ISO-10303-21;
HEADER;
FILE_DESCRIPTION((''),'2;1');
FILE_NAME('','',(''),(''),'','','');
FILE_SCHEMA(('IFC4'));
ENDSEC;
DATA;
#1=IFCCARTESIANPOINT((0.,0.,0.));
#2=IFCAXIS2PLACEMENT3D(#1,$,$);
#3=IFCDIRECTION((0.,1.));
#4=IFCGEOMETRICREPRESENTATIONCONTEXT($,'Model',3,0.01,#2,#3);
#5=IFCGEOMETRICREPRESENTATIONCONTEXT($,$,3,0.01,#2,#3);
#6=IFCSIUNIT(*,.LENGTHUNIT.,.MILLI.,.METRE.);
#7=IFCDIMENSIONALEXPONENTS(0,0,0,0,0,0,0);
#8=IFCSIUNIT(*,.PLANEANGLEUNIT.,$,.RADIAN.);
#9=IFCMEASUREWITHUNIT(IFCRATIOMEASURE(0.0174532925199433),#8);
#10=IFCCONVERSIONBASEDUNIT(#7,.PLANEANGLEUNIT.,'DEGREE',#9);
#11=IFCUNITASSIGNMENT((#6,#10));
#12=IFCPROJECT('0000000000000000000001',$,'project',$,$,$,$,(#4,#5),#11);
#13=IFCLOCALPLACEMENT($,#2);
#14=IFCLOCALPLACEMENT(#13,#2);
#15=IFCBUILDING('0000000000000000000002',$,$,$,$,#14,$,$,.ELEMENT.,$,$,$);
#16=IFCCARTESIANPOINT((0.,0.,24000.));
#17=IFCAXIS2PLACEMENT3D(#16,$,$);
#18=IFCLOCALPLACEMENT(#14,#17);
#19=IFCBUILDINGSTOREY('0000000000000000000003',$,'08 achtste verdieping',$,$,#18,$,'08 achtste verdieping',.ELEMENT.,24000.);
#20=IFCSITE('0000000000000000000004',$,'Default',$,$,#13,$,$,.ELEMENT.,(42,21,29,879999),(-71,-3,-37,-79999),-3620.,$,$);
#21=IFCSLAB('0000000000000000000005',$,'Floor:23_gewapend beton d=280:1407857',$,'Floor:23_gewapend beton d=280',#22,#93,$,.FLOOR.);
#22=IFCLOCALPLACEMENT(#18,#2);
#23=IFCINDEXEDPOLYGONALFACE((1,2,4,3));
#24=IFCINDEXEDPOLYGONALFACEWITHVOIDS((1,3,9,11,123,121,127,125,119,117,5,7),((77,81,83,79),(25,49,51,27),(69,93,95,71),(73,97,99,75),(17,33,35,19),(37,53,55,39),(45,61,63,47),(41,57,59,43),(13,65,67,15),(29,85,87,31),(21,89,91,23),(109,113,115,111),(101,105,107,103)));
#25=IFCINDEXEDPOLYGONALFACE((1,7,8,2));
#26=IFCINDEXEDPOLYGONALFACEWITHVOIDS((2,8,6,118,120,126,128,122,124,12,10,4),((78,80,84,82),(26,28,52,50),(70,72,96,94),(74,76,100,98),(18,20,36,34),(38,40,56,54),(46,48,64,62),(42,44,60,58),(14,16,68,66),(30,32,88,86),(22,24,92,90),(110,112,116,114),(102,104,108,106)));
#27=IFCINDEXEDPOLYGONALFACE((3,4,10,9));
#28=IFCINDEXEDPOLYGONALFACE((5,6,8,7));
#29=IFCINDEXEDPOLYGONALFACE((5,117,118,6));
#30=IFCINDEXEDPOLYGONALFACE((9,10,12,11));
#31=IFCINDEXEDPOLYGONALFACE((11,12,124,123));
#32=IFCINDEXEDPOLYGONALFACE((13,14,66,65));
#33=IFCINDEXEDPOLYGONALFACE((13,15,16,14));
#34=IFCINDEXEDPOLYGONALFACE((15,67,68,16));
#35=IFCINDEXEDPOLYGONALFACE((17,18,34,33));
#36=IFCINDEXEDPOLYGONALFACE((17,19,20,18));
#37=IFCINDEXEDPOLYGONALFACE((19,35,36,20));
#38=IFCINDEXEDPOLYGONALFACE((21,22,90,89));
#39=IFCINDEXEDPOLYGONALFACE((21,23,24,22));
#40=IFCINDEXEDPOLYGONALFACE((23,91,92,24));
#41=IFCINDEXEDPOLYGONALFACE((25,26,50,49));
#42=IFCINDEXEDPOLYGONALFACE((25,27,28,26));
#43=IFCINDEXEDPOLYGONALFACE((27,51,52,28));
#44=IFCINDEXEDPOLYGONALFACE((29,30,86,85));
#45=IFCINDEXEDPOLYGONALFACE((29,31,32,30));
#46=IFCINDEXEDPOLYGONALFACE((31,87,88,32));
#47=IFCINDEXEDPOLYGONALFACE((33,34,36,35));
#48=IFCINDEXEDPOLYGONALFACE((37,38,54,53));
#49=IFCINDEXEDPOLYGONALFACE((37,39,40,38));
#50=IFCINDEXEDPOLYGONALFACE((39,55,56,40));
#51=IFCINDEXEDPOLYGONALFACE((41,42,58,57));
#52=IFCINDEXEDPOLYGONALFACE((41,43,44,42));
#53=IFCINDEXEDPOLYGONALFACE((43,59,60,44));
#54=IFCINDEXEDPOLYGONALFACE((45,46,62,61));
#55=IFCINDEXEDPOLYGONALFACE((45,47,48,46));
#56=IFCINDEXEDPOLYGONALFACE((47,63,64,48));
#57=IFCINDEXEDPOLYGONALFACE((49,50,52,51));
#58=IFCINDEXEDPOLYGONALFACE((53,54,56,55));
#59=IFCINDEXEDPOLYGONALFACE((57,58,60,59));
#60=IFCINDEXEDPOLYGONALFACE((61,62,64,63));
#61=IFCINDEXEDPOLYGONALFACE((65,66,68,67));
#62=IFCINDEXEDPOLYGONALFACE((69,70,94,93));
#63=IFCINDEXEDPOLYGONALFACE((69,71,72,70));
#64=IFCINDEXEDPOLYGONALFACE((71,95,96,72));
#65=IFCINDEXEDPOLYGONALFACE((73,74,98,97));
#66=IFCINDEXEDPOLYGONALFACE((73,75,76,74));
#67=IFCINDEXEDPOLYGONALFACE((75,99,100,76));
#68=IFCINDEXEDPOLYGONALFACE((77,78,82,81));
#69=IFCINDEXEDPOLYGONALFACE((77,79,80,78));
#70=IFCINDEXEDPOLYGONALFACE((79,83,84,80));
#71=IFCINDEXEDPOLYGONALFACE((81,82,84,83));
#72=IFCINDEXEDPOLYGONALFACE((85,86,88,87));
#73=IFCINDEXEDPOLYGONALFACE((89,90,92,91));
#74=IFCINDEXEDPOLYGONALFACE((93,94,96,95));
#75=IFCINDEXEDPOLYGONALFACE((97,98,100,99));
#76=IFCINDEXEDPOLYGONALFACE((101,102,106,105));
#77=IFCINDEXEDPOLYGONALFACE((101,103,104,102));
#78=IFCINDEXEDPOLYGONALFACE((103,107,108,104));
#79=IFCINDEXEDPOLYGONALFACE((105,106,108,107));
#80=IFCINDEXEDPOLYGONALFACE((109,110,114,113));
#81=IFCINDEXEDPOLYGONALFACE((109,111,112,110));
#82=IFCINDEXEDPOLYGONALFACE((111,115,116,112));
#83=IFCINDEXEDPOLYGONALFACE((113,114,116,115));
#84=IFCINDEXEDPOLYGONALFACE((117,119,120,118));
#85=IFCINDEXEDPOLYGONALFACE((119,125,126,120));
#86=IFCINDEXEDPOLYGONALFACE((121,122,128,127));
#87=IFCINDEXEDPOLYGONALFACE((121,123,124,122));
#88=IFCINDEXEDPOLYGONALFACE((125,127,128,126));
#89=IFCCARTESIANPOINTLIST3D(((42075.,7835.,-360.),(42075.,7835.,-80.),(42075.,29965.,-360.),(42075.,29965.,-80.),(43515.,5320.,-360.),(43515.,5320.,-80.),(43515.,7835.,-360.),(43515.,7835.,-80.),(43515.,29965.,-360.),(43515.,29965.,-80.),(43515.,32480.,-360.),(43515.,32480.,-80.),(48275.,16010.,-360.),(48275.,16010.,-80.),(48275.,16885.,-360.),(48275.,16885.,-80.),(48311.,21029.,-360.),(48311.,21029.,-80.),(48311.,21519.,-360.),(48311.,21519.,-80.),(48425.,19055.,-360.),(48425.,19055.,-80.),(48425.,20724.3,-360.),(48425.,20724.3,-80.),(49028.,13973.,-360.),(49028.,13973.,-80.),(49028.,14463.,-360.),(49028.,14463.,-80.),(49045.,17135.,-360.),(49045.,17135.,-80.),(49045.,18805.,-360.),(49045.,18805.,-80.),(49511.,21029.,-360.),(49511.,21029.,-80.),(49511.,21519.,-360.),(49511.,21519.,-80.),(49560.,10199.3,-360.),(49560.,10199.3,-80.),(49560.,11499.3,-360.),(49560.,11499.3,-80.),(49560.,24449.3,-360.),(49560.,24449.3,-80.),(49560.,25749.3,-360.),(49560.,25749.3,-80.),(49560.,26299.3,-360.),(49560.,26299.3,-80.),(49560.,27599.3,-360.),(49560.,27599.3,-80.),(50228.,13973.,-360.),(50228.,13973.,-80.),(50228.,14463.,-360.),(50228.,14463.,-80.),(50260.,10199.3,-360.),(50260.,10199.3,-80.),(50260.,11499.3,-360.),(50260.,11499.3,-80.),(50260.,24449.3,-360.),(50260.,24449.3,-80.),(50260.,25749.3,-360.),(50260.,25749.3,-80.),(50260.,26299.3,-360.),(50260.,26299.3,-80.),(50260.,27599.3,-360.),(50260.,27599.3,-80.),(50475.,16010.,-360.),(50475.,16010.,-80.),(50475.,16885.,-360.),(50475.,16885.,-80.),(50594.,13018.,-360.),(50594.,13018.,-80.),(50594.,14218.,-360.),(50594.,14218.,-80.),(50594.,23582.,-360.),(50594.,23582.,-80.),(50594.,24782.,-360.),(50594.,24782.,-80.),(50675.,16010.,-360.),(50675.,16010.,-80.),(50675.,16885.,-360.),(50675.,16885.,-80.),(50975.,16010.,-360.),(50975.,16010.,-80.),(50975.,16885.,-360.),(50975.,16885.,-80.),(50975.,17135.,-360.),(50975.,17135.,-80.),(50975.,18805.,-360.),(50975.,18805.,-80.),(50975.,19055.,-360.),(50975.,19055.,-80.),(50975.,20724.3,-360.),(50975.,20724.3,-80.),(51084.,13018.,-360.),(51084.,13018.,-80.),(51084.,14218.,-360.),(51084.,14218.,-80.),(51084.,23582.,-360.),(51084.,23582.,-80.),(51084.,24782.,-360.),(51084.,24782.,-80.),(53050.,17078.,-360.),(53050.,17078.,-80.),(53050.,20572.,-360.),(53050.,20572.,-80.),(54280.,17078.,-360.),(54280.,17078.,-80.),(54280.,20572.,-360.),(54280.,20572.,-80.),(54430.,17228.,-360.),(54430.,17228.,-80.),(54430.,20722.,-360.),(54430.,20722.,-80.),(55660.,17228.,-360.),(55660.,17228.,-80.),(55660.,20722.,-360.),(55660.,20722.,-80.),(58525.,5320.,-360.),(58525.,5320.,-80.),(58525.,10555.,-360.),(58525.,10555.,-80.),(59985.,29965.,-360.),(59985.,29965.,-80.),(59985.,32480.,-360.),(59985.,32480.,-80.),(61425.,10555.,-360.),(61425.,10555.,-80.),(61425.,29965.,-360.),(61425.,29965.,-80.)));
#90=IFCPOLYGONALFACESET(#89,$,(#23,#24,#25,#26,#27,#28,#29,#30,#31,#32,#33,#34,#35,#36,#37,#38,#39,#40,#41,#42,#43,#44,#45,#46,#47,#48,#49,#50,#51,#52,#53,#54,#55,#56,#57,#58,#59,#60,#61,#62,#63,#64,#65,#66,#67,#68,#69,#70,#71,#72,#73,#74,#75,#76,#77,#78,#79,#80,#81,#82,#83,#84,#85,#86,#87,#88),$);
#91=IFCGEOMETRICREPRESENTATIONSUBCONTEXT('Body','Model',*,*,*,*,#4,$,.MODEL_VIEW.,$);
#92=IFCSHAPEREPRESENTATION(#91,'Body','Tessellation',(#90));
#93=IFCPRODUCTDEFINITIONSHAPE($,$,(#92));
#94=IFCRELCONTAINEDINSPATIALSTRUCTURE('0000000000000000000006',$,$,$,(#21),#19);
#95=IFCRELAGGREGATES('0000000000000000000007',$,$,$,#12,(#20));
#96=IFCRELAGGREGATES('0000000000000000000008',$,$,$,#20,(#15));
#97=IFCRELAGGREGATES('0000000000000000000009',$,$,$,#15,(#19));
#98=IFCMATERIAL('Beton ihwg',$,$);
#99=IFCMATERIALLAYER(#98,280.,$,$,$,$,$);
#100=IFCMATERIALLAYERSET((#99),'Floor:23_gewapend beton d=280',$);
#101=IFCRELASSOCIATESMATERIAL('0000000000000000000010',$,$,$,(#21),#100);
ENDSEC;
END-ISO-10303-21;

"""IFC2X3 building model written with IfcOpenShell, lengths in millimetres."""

from ifc_helpers import new_model, entity, si_unit, converted_unit, direction, frame, frame_2d, origin, place, context, subcontext, project, spatial, polyline, rectangle, outline, extrude, material, layer, layer_set, layer_usage, element, save


model = new_model("IFC2X3")

# Units and contexts
model_context = context("Model", 3, precision=0.01, world=origin(), true_north=direction((0.0, 1.0)))
context_of_model = context(None, 3, precision=0.01, world=origin(), true_north=direction((0.0, 1.0)))
body_context = subcontext(model_context, "Body", "Model", "MODEL_VIEW")
ifc_project = project(units=[si_unit("LENGTHUNIT", "METRE", prefix="MILLI"), converted_unit("PLANEANGLEUNIT", "DEGREE", entity("IfcRatioMeasure", 0.0174532925199433), si_unit("PLANEANGLEUNIT", "RADIAN"), dimensions=[0, 0, 0, 0, 0, 0, 0])], contexts=[model_context, context_of_model])

# Site, building, storey
site_placement = place(None, origin())
site = spatial("IfcSite", under=ifc_project, at=site_placement, Name="Default", CompositionType="ELEMENT", RefLatitude=(42, 21, 29, 879999), RefLongitude=(-71, -3, -37, -79999), RefElevation=-3620.0)
building_placement = place(site_placement, origin())
building = spatial("IfcBuilding", under=site, at=building_placement, CompositionType="ELEMENT")
storey_placement = place(building_placement, frame((0.0, 0.0, 24000.0)))
storey = spatial("IfcBuildingStorey", under=building, at=storey_placement, Name="08 achtste verdieping", LongName="08 achtste verdieping", CompositionType="ELEMENT", Elevation=24000.0)

# Slab, openings
ifc_material_1 = material(Name="Beton ihwg")
ifc_layer_1 = layer(ifc_material_1, 280.0)
ifc_layer_set_1 = layer_set([ifc_layer_1], Name="Floor:23_gewapend beton d=280")
ifc_layer_usage_1 = layer_usage(ifc_layer_set_1, "AXIS3", "POSITIVE", 0.0)
slab_1_placement = place(storey_placement, frame((42075.0, 5320.0, -360.0)))
slab_1 = element("IfcSlab", 1, at=slab_1_placement, inside=storey, material=ifc_layer_usage_1, Name="Floor:23_gewapend beton d=280:1407857", ObjectType="Floor:23_gewapend beton d=280", PredefinedType="FLOOR", context=body_context, shape_type="SweptSolid", body=[
    extrude(outline(polyline([(8235.0, 13580.0), (-8235.0, 13580.0), (-8235.0, 11065.0), (-9675.0, 11065.0), (-9675.0, -8345.0), (-6775.0, -8345.0), (-6775.0, -13580.0), (8235.0, -13580.0), (8235.0, -11065.0), (9675.0, -11065.0), (9675.0, 11065.0), (8235.0, 11065.0), (8235.0, 13580.0)])), frame((9675.0, 13580.0, 280.0), z_axis=(0.0, 0.0, -1.0), x_axis=(-1.0, 0.0, 0.0)), (0.0, 0.0, 1.0), 280.0),
])
opening_1_placement = place(storey_placement, frame((42075.0, 5320.0, -360.0)))
element("IfcOpeningElement", 2, at=opening_1_placement, cuts=slab_1, ObjectType="Opening", context=body_context, shape_type="SweptSolid", body=[
    extrude(rectangle(XDim=1669.3, YDim=2550.0, at=frame_2d((2050.0, 989.6), x_axis=(0.0, 1.0))), frame((9675.0, 13580.0, 280.0), z_axis=(0.0, 0.0, -1.0), x_axis=(-1.0, 0.0, 0.0)), (0.0, 0.0, 1.0), 280.0),
])
opening_2_placement = place(storey_placement, frame((42075.0, 5320.0, -360.0)))
element("IfcOpeningElement", 3, at=opening_2_placement, cuts=slab_1, ObjectType="Opening", context=body_context, shape_type="SweptSolid", body=[
    extrude(rectangle(XDim=1670.0, YDim=1930.0, at=frame_2d((1740.0, -930.0), x_axis=(0.0, 1.0))), frame((9675.0, 13580.0, 280.0), z_axis=(0.0, 0.0, -1.0), x_axis=(-1.0, 0.0, 0.0)), (0.0, 0.0, 1.0), 280.0),
])
opening_3_placement = place(storey_placement, frame((42075.0, 5320.0, -360.0)))
element("IfcOpeningElement", 4, at=opening_3_placement, cuts=slab_1, ObjectType="Opening", context=body_context, shape_type="SweptSolid", body=[
    extrude(rectangle(XDim=1300.0, YDim=700.0, at=frame_2d((1840.0, 8049.3), x_axis=(0.0, 1.0))), frame((9675.0, 13580.0, 280.0), z_axis=(0.0, 0.0, -1.0), x_axis=(-1.0, 0.0, 0.0)), (0.0, 0.0, 1.0), 280.0),
])
opening_4_placement = place(storey_placement, frame((42075.0, 5320.0, -360.0)))
element("IfcOpeningElement", 5, at=opening_4_placement, cuts=slab_1, ObjectType="Opening", context=body_context, shape_type="SweptSolid", body=[
    extrude(rectangle(XDim=1300.0, YDim=700.0, at=frame_2d((1840.0, 6199.3), x_axis=(0.0, 1.0))), frame((9675.0, 13580.0, 280.0), z_axis=(0.0, 0.0, -1.0), x_axis=(-1.0, 0.0, 0.0)), (0.0, 0.0, 1.0), 280.0),
])
opening_5_placement = place(storey_placement, frame((42075.0, 5320.0, -360.0)))
element("IfcOpeningElement", 6, at=opening_5_placement, cuts=slab_1, ObjectType="Opening", context=body_context, shape_type="SweptSolid", body=[
    extrude(rectangle(XDim=1300.0, YDim=700.0, at=frame_2d((1840.0, -8050.7), x_axis=(0.0, 1.0))), frame((9675.0, 13580.0, 280.0), z_axis=(0.0, 0.0, -1.0), x_axis=(-1.0, 0.0, 0.0)), (0.0, 0.0, 1.0), 280.0),
])
opening_6_placement = place(storey_placement, frame((42075.0, 5320.0, -360.0)))
element("IfcOpeningElement", 7, at=opening_6_placement, cuts=slab_1, ObjectType="Opening", context=body_context, shape_type="SweptSolid", body=[
    extrude(rectangle(XDim=875.0, YDim=2200.0, at=frame_2d((2375.0, -2452.5), x_axis=(0.0, 1.0))), frame((9675.0, 13580.0, 280.0), z_axis=(0.0, 0.0, -1.0), x_axis=(-1.0, 0.0, 0.0)), (0.0, 0.0, 1.0), 280.0),
])
opening_7_placement = place(storey_placement, frame((42075.0, 5320.0, -360.0)))
element("IfcOpeningElement", 8, at=opening_7_placement, cuts=slab_1, ObjectType="Opening", context=body_context, shape_type="SweptSolid", body=[
    extrude(rectangle(XDim=875.0, YDim=300.0, at=frame_2d((925.0, -2452.5), x_axis=(0.0, 1.0))), frame((9675.0, 13580.0, 280.0), z_axis=(0.0, 0.0, -1.0), x_axis=(-1.0, 0.0, 0.0)), (0.0, 0.0, 1.0), 280.0),
])
opening_8_placement = place(storey_placement, frame((42075.0, 5320.0, -360.0)))
element("IfcOpeningElement", 9, at=opening_8_placement, cuts=slab_1, ObjectType="Opening", context=body_context, shape_type="SweptSolid", body=[
    extrude(rectangle(XDim=3494.0, YDim=1230.0, at=frame_2d((-3295.0, 75.0), x_axis=(0.0, 1.0))), frame((9675.0, 13580.0, 280.0), z_axis=(0.0, 0.0, -1.0), x_axis=(-1.0, 0.0, 0.0)), (0.0, 0.0, 1.0), 280.0),
])
opening_9_placement = place(storey_placement, frame((42075.0, 5320.0, -360.0)))
element("IfcOpeningElement", 10, at=opening_9_placement, cuts=slab_1, ObjectType="Opening", context=body_context, shape_type="SweptSolid", body=[
    extrude(rectangle(XDim=3494.0, YDim=1230.0, at=frame_2d((-1915.0, -75.0), x_axis=(0.0, 1.0))), frame((9675.0, 13580.0, 280.0), z_axis=(0.0, 0.0, -1.0), x_axis=(-1.0, 0.0, 0.0)), (0.0, 0.0, 1.0), 280.0),
])
opening_10_placement = place(storey_placement, frame((42075.0, 5320.0, -360.0)))
element("IfcOpeningElement", 11, at=opening_10_placement, cuts=slab_1, ObjectType="Opening", context=body_context, shape_type="SweptSolid", body=[
    extrude(rectangle(XDim=490.0, YDim=1200.0, at=frame_2d((911.0, 5282.0), x_axis=(-1.0, 0.0))), frame((9675.0, 13580.0, 280.0), z_axis=(0.0, 0.0, -1.0), x_axis=(-1.0, 0.0, 0.0)), (0.0, 0.0, 1.0), 280.0),
])
opening_11_placement = place(storey_placement, frame((42075.0, 5320.0, -360.0)))
element("IfcOpeningElement", 12, at=opening_11_placement, cuts=slab_1, ObjectType="Opening", context=body_context, shape_type="SweptSolid", body=[
    extrude(rectangle(XDim=490.0, YDim=1200.0, at=frame_2d((2839.0, 2374.0), x_axis=(0.0, 1.0))), frame((9675.0, 13580.0, 280.0), z_axis=(0.0, 0.0, -1.0), x_axis=(-1.0, 0.0, 0.0)), (0.0, 0.0, 1.0), 280.0),
])
opening_12_placement = place(storey_placement, frame((42075.0, 5320.0, -360.0)))
element("IfcOpeningElement", 13, at=opening_12_placement, cuts=slab_1, ObjectType="Opening", context=body_context, shape_type="SweptSolid", body=[
    extrude(rectangle(XDim=490.0, YDim=1200.0, at=frame_2d((911.0, -5282.0), x_axis=(-1.0, 0.0))), frame((9675.0, 13580.0, 280.0), z_axis=(0.0, 0.0, -1.0), x_axis=(-1.0, 0.0, 0.0)), (0.0, 0.0, 1.0), 280.0),
])
opening_13_placement = place(storey_placement, frame((42075.0, 5320.0, -360.0)))
element("IfcOpeningElement", 14, at=opening_13_placement, cuts=slab_1, ObjectType="Opening", context=body_context, shape_type="SweptSolid", body=[
    extrude(rectangle(XDim=490.0, YDim=1200.0, at=frame_2d((2122.0, -4682.0), x_axis=(0.0, 1.0))), frame((9675.0, 13580.0, 280.0), z_axis=(0.0, 0.0, -1.0), x_axis=(-1.0, 0.0, 0.0)), (0.0, 0.0, 1.0), 280.0),
])

save(model, "model.ifc")
